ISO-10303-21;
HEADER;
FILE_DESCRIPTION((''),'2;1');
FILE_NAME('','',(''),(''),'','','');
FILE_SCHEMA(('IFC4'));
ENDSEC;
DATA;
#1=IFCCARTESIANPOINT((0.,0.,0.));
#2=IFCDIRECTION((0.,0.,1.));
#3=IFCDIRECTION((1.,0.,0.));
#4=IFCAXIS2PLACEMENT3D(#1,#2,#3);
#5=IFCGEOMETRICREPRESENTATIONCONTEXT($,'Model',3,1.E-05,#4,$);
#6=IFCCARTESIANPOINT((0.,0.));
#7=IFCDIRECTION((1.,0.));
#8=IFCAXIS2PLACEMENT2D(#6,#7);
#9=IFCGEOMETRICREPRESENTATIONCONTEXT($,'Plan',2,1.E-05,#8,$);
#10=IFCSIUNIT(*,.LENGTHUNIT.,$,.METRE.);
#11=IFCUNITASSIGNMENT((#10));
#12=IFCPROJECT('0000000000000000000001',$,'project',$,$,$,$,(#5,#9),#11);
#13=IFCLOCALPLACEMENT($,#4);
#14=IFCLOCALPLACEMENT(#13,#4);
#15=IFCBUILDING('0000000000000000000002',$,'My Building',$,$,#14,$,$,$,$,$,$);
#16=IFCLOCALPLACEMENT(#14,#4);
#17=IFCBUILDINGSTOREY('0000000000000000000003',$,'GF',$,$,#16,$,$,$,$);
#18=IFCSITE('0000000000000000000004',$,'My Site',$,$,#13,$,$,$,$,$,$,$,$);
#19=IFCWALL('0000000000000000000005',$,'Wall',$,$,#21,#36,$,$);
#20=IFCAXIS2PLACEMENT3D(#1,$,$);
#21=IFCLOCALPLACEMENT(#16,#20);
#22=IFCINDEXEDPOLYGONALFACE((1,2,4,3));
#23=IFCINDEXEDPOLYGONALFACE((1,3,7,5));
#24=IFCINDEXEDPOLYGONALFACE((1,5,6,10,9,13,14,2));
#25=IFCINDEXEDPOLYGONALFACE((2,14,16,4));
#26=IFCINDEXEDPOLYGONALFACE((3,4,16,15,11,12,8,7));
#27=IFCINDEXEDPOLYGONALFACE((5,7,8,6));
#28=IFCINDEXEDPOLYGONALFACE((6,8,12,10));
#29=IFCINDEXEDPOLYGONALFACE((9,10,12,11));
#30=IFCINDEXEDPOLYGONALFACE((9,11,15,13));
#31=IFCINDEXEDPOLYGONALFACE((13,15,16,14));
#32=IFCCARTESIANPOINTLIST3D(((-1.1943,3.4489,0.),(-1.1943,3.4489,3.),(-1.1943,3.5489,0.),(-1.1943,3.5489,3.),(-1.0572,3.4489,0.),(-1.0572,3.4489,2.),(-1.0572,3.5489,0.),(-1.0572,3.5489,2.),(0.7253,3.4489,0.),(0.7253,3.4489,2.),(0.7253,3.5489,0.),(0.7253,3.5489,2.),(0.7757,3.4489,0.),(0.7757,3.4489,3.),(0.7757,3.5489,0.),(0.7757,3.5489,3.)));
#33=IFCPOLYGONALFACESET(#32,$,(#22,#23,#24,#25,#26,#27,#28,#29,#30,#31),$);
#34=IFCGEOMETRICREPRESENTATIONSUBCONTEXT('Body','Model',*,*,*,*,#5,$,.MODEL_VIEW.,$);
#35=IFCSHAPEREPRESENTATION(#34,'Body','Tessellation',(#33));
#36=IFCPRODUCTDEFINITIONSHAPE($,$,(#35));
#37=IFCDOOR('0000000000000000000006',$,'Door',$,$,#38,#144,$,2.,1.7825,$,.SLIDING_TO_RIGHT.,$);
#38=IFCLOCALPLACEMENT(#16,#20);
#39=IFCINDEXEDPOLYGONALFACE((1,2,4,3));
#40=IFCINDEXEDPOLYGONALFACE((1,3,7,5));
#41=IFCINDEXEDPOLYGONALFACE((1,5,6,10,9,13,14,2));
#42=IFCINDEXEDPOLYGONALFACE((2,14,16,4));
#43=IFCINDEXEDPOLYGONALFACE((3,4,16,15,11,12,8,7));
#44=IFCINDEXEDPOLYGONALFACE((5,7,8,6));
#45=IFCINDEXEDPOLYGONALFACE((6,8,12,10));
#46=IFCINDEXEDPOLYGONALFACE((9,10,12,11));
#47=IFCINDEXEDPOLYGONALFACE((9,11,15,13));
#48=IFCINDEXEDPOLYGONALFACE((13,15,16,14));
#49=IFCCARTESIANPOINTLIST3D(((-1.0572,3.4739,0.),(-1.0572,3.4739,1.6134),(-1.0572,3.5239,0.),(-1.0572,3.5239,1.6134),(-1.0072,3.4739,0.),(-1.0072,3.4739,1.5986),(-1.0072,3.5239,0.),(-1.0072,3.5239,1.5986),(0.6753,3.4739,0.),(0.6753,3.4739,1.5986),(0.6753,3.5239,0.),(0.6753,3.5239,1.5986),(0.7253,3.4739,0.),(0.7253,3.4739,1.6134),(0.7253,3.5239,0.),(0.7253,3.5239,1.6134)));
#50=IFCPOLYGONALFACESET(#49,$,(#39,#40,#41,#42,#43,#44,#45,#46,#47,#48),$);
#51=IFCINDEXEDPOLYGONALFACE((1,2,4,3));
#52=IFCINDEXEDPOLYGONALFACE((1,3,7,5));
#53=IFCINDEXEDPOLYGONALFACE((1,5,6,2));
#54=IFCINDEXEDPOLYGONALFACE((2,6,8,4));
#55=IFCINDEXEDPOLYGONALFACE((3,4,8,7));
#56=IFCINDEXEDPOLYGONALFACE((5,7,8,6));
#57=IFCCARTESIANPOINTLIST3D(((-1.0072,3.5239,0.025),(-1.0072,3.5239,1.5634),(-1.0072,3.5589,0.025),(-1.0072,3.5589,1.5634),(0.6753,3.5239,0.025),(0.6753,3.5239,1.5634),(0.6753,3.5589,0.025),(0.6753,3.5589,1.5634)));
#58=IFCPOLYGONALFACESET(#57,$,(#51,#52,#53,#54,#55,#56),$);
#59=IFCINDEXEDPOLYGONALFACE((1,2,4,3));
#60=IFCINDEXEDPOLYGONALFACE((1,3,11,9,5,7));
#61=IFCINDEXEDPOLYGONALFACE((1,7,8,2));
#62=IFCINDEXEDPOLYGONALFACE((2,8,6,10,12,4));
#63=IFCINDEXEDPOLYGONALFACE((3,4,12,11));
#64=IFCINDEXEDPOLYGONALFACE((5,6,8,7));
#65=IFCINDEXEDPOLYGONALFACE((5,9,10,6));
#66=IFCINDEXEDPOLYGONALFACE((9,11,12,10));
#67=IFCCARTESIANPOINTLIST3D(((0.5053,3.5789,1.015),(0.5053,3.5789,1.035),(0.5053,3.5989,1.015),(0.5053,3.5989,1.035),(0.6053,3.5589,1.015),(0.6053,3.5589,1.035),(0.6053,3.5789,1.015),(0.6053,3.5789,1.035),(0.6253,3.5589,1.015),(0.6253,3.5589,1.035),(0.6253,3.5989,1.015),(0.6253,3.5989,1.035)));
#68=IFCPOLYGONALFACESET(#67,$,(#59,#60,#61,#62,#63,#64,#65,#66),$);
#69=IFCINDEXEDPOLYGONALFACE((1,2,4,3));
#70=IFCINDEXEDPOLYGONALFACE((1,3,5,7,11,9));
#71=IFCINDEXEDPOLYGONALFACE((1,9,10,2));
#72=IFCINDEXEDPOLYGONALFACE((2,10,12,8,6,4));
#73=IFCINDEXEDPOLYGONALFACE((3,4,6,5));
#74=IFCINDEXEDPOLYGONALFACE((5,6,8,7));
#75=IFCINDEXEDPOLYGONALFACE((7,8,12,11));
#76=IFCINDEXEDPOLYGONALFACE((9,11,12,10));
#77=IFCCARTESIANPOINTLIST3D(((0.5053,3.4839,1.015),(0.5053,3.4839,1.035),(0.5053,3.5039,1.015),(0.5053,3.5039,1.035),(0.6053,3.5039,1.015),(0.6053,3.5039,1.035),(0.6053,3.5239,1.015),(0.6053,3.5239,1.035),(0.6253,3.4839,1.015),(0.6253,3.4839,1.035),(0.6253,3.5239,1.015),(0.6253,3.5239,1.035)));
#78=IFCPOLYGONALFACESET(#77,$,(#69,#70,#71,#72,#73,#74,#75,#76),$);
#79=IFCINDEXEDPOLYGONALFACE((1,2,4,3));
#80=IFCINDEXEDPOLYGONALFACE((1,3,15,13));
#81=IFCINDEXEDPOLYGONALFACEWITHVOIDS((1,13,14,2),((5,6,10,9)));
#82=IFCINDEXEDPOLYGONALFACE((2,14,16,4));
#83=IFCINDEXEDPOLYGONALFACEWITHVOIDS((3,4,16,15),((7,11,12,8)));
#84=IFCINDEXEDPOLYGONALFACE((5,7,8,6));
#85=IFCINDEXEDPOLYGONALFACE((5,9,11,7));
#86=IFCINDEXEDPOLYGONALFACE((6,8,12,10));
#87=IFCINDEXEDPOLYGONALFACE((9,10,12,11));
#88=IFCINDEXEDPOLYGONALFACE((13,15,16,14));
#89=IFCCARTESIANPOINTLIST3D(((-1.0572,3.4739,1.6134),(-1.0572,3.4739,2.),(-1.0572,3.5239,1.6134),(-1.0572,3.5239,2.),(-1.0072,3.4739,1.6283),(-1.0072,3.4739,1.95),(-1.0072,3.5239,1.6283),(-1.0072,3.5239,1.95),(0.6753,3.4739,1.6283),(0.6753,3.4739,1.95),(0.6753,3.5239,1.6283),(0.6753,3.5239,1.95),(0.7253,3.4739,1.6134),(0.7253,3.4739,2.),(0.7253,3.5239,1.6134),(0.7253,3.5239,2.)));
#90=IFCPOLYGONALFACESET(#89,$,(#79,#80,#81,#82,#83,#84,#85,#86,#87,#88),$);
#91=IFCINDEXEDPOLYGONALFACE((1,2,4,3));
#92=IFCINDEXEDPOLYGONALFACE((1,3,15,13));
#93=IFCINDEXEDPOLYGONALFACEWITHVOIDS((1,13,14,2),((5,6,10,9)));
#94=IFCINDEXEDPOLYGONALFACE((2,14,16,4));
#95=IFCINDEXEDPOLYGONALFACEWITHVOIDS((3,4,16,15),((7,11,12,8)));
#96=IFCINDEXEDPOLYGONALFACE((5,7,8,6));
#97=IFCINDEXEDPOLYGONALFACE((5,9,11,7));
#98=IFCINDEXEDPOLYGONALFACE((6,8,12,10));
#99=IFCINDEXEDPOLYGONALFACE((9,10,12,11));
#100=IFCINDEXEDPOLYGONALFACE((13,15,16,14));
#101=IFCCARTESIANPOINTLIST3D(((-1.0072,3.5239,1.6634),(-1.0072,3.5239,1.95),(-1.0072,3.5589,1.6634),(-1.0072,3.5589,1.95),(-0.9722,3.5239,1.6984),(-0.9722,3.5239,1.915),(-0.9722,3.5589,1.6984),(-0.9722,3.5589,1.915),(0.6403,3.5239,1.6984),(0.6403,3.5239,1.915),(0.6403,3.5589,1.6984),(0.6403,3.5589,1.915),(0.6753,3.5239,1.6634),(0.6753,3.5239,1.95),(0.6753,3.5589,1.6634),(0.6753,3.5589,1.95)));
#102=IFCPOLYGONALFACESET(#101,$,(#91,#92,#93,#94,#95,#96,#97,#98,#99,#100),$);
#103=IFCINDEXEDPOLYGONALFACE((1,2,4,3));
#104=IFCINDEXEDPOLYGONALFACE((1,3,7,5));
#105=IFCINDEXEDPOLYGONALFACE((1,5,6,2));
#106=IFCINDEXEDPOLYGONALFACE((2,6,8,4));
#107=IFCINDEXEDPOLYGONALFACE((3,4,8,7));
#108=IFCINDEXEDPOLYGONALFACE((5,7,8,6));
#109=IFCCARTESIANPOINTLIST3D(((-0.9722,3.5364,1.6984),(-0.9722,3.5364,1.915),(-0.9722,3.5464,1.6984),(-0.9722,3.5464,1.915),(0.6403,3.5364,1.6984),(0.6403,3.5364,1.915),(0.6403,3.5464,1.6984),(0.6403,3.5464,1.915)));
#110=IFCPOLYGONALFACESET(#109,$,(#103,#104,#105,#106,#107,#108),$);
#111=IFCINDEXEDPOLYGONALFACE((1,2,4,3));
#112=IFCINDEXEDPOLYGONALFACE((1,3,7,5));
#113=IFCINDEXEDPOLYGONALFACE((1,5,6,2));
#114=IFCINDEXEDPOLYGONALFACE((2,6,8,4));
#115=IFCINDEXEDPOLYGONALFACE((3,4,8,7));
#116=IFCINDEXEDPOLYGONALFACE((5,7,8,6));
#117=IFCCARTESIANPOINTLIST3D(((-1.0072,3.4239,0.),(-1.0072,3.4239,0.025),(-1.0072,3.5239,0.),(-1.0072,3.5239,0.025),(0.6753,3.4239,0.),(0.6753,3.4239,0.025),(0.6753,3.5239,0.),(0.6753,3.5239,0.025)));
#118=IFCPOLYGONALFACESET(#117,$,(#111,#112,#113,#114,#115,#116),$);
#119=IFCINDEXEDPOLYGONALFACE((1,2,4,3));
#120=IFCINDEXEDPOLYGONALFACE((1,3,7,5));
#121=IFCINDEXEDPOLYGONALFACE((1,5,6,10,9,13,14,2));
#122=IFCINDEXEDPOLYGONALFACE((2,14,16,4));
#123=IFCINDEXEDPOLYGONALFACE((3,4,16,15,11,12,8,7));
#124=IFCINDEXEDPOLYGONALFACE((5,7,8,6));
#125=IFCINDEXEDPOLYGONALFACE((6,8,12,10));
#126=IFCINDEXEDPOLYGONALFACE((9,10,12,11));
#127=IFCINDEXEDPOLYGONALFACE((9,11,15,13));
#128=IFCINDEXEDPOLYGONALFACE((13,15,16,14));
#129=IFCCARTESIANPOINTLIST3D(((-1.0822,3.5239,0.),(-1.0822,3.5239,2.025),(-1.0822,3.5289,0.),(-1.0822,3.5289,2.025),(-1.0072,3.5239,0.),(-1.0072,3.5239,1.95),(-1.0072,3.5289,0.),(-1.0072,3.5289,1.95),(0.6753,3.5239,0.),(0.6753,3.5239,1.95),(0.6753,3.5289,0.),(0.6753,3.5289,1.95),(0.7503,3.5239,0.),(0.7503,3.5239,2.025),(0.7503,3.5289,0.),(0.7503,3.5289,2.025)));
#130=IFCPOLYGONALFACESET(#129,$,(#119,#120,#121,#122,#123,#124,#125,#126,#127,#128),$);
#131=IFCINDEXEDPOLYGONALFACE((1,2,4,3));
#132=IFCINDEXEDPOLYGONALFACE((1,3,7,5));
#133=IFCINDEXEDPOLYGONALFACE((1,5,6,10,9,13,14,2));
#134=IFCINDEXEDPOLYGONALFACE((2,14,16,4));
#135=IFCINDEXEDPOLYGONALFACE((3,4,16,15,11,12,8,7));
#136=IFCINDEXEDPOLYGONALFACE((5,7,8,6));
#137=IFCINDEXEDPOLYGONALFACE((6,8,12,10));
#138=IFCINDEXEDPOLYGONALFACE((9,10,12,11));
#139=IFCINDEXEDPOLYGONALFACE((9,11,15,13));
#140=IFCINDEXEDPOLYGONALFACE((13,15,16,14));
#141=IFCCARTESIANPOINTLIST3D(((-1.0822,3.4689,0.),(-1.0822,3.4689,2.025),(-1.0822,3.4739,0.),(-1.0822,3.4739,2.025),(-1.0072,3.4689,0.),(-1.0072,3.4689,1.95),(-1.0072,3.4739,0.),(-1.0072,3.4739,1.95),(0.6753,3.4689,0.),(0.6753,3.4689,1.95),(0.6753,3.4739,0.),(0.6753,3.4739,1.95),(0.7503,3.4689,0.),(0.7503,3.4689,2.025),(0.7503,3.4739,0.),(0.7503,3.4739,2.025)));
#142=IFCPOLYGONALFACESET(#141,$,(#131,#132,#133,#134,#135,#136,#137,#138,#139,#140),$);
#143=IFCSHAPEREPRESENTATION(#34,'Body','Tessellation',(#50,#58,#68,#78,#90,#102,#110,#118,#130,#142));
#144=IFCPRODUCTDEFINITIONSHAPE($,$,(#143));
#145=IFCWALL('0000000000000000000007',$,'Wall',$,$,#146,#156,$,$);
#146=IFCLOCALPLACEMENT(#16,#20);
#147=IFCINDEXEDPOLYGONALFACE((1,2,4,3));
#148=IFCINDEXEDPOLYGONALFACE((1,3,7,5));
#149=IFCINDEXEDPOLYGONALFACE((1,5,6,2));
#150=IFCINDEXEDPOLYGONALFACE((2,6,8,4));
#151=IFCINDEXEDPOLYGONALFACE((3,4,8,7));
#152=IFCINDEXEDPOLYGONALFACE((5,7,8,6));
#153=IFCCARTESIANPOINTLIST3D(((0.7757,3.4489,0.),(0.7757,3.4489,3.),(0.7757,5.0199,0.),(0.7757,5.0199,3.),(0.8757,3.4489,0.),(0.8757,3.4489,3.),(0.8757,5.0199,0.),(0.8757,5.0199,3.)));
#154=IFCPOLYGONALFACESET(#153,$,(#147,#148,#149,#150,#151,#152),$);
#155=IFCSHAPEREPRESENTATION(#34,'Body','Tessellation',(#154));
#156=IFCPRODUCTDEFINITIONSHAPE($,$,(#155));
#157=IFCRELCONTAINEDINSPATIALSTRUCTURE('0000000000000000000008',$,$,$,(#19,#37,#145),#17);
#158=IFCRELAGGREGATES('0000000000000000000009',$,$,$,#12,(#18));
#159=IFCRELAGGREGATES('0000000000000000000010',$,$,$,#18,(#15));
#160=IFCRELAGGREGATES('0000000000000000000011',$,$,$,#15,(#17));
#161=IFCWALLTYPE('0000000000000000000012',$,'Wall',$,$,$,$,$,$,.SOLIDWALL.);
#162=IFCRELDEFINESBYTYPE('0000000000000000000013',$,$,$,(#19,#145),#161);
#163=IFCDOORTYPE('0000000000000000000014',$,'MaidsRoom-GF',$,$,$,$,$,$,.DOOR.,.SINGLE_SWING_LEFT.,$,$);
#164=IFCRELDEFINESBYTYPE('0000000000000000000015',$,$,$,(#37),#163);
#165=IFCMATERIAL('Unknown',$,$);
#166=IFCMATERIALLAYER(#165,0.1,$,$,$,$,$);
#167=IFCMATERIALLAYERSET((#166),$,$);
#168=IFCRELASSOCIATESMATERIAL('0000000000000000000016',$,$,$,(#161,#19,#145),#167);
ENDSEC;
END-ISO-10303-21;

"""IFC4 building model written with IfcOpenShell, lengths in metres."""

from ifc_helpers import new_model, entity, si_unit, frame, origin_with_axes, origin_2d_with_axis, place, context, subcontext, project, spatial, line, indexed_curve, outline, extrude, shape, source, transform, mapped, material, layer, layer_set, layer_usage, type_object, type_shapes, element, fill, save


model = new_model("IFC4")

# Units and contexts
model_context = context("Model", 3, precision=1e-05, world=origin_with_axes())
plan_context = context("Plan", 2, precision=1e-05, world=origin_2d_with_axis())
body_context_1 = subcontext(model_context, "Body", "Model", "MODEL_VIEW")
body_context_2 = subcontext(plan_context, "Body", "Plan", "PLAN_VIEW")
ifc_project = project(units=[si_unit("LENGTHUNIT", "METRE")], contexts=[model_context, plan_context])

# Site, building, storey
site_placement = place(None, origin_with_axes())
site = spatial("IfcSite", under=ifc_project, at=site_placement, Name="My Site")
building_placement = place(site_placement, origin_with_axes())
building = spatial("IfcBuilding", under=site, at=building_placement, Name="My Building")
storey_placement = place(building_placement, origin_with_axes())
storey = spatial("IfcBuildingStorey", under=building, at=storey_placement, Name="GF")

# Shared definitions
ifc_material = material(Name="Unknown")

# Shared definitions
ifc_layer_1 = layer(ifc_material, 0.1)
ifc_layer_set_1 = layer_set([ifc_layer_1])
wall_type = type_object("IfcWallType", Name="Wall", PredefinedType="SOLIDWALL", material=ifc_layer_set_1)

# Wall, opening, door
ifc_layer_usage_1 = layer_usage(ifc_layer_set_1, "AXIS2", "POSITIVE", 0.0)
wall_1_placement = place(storey_placement, frame((0.7757, 3.5489, 0.0), z_axis=(0.0, 0.0, 1.0), x_axis=(-1.0, 0.0, 0.0)))
wall_1 = element("IfcWall", 1, at=wall_1_placement, inside=storey, type_object=wall_type, material=ifc_layer_usage_1, Name="Wall", context=body_context_1, shape_type="SweptSolid", body=[
    extrude(outline(indexed_curve([(0.0, 0.0), (0.0, 0.1), (1.97, 0.1), (1.97, 0.0)], segments=[line(1, 2, 3, 4, 1)])), origin_with_axes(), (0.0, 0.0, 1.0), 3.0),
])
shared_shape_1 = source(origin_with_axes(), body_context_1, "Body", "SweptSolid", [
    extrude(outline(indexed_curve([(0.0, 0.0), (1.7825, 0.0), (1.7825, 2.0), (0.0, 2.0)], segments=[line(1, 2, 3, 4, 1)])), frame((0.0, -0.6, 0.0), z_axis=(0.0, -1.0, 0.0), x_axis=(1.0, 0.0, 0.0)), (0.0, 0.0, -1.0), 1.2),
])
opening_1_placement = place(wall_1_placement, frame((0.0505, 0.025, 0.0), z_axis=(0.0, 0.0, 1.0), x_axis=(1.0, -0.000001, 0.0)))
opening_1 = element("IfcOpeningElement", 2, at=opening_1_placement, cuts=wall_1, PredefinedType="OPENING", context=body_context_1, shape_type="MappedRepresentation", body=[
    mapped(shared_shape_1, transform((0.0, 0.0, 0.0), x_axis=(1.0, 0.0, 0.0), y_axis=(0.0, 1.0, 0.0), z_axis=(0.0, 0.0, 1.0), scale=1.0)),
])
door_type_1 = type_object("IfcDoorType", Name="MaidsRoom-GF", OperationType="SINGLE_SWING_LEFT", PredefinedType="DOOR")
shared_shape_2 = source(origin_with_axes(), body_context_1, "Body", "SweptSolid", [
    extrude(outline(indexed_curve([(0.0, 0.0), (0.0, 1.6134), (1.7825, 1.6134), (1.7825, 0.0), (1.7325, 0.0), (1.7325, 1.5986), (0.05, 1.5986), (0.05, 0.0)], segments=[line(1, 2, 3, 4, 5, 6, 7, 8, 1)])), frame((0.0, 0.0, 0.0), z_axis=(0.0, -1.0, 0.0), x_axis=(1.0, 0.0, 0.0)), (0.0, 0.0, -1.0), 0.05),
    extrude(outline(indexed_curve([(0.0, 0.0), (1.6825, 0.0), (1.6825, 0.035), (0.0, 0.035)], segments=[line(1, 2, 3, 4, 1)])), frame((0.05, -0.035, 0.025), z_axis=(0.0, 0.0, 1.0), x_axis=(1.0, 0.0, 0.0)), (0.0, 0.0, 1.0), 1.5384),
    extrude(outline(indexed_curve([(0.0, 0.0), (0.0, -0.04), (0.12, -0.04), (0.12, -0.02), (0.02, -0.02), (0.02, 0.0)], segments=[line(1, 2, 3, 4, 5, 6, 1)])), frame((0.1, -0.035, 1.015), z_axis=(0.0, 0.0, 1.0), x_axis=(1.0, 0.0, 0.0)), (0.0, 0.0, 1.0), 0.02),
    extrude(outline(indexed_curve([(0.0, 0.0), (0.0, 0.04), (0.12, 0.04), (0.12, 0.02), (0.02, 0.02), (0.02, 0.0)], segments=[line(1, 2, 3, 4, 5, 6, 1)])), frame((0.1, 0.0, 1.015), z_axis=(0.0, 0.0, 1.0), x_axis=(1.0, 0.0, 0.0)), (0.0, 0.0, 1.0), 0.02),
    extrude(outline(indexed_curve([(0.0, 0.0), (1.7825, 0.0), (1.7825, 0.3866), (0.0, 0.3866)], segments=[line(1, 2, 3, 4, 1)]), holes=[indexed_curve([(0.05, 0.0148), (1.7325, 0.0148), (1.7325, 0.3366), (0.05, 0.3366)], segments=[line(1, 2, 3, 4, 1)])]), frame((0.0, 0.0, 1.6134), z_axis=(0.0, -1.0, 0.0), x_axis=(1.0, 0.0, 0.0)), (0.0, 0.0, -1.0), 0.05),
    extrude(outline(indexed_curve([(0.0, 0.0), (1.6825, 0.0), (1.6825, 0.2866), (0.0, 0.2866)], segments=[line(1, 2, 3, 4, 1)]), holes=[indexed_curve([(0.035, 0.035), (1.6475, 0.035), (1.6475, 0.2516), (0.035, 0.2516)], segments=[line(1, 2, 3, 4, 1)])]), frame((0.05, -0.035, 1.6634), z_axis=(0.0, -1.0, 0.0), x_axis=(1.0, 0.0, 0.0)), (0.0, 0.0, -1.0), 0.035),
    extrude(outline(indexed_curve([(0.035, 0.035), (1.6475, 0.035), (1.6475, 0.2516), (0.035, 0.2516)], segments=[line(1, 2, 3, 4, 1)])), frame((0.05, -0.0225, 1.6634), z_axis=(0.0, -1.0, 0.0), x_axis=(1.0, 0.0, 0.0)), (0.0, 0.0, -1.0), 0.01),
    extrude(outline(indexed_curve([(0.0, 0.0), (1.6825, 0.0), (1.6825, 0.1), (0.0, 0.1)], segments=[line(1, 2, 3, 4, 1)])), frame((0.05, 0.0, 0.0), z_axis=(0.0, 0.0, 1.0), x_axis=(1.0, 0.0, 0.0)), (0.0, 0.0, 1.0), 0.025),
    extrude(outline(indexed_curve([(0.0, 0.0), (0.0, 2.025), (1.8325, 2.025), (1.8325, 0.0), (1.7575, 0.0), (1.7575, 1.95), (0.075, 1.95), (0.075, 0.0)], segments=[line(1, 2, 3, 4, 5, 6, 7, 8, 1)])), frame((-0.025, -0.005, 0.0), z_axis=(0.0, -1.0, 0.0), x_axis=(1.0, 0.0, 0.0)), (0.0, 0.0, -1.0), 0.005),
    extrude(outline(indexed_curve([(0.0, 0.0), (0.0, 2.025), (1.8325, 2.025), (1.8325, 0.0), (1.7575, 0.0), (1.7575, 1.95), (0.075, 1.95), (0.075, 0.0)], segments=[line(1, 2, 3, 4, 5, 6, 7, 8, 1)])), frame((-0.025, 0.05, 0.0), z_axis=(0.0, -1.0, 0.0), x_axis=(1.0, 0.0, 0.0)), (0.0, 0.0, -1.0), 0.005),
])
shared_shape_3 = source(origin_with_axes(), body_context_2, "Body", "Curve2D", [
    entity("IfcIndexedPolyCurve", entity("IfcCartesianPointList2D", [[0.0, 0.0], [0.05, 0.0], [0.05, 0.05], [0.0, 0.05]]), [entity("IfcLineIndex", [1, 2, 3, 4, 1])]),
    entity("IfcIndexedPolyCurve", entity("IfcCartesianPointList2D", [[1.7825, 0.0], [1.7325, 0.0], [1.7325, 0.05], [1.7825, 0.05]]), [entity("IfcLineIndex", [1, 2, 3, 4, 1])]),
    entity("IfcIndexedPolyCurve", entity("IfcCartesianPointList2D", [[2.5737, -0.035], [0.8912, -0.035], [0.8912, 0.0], [2.5737, 0.0]]), [entity("IfcLineIndex", [1, 2, 3, 4, 1])]),
])
type_shapes(door_type_1, [shared_shape_2, shared_shape_3])
door_1_placement = place(opening_1_placement, frame((0.0, 0.0, 0.0), z_axis=(0.0, 0.0, 1.0), x_axis=(1.0, 0.0, 0.0)))
door_1 = element("IfcDoor", 3, at=door_1_placement, inside=storey, type_object=door_type_1, Name="Door", OperationType="SLIDING_TO_RIGHT", OverallHeight=2.0, OverallWidth=1.7825, shapes=[
    shape(body_context_1, "Body", "MappedRepresentation", [mapped(shared_shape_2, transform((0.0, 0.0, 0.0), x_axis=(1.0, 0.0, 0.0), y_axis=(0.0, 1.0, 0.0), z_axis=(0.0, 0.0, 1.0), scale=1.0))]),
    shape(body_context_2, "Body", "MappedRepresentation", [mapped(shared_shape_3, transform((0.0, 0.0, 0.0), x_axis=(1.0, 0.0, 0.0), y_axis=(0.0, 1.0, 0.0), z_axis=(0.0, 0.0, 1.0), scale=1.0))]),
])
fill(opening_1, door_1)

# Wall
ifc_layer_usage_2 = layer_usage(ifc_layer_set_1, "AXIS2", "POSITIVE", 0.0)
wall_2_placement = place(storey_placement, frame((0.7757, 5.0199, 0.0), z_axis=(0.0, 0.0, 1.0), x_axis=(0.0, -1.0, 0.0)))
element("IfcWall", 4, at=wall_2_placement, inside=storey, type_object=wall_type, material=ifc_layer_usage_2, Name="Wall", context=body_context_1, shape_type="SweptSolid", body=[
    extrude(outline(indexed_curve([(0.0, 0.0), (0.0, 0.1), (1.571, 0.1), (1.571, 0.0)], segments=[line(1, 2, 3, 4, 1)])), origin_with_axes(), (0.0, 0.0, 1.0), 3.0),
])

save(model, "model.ifc")
